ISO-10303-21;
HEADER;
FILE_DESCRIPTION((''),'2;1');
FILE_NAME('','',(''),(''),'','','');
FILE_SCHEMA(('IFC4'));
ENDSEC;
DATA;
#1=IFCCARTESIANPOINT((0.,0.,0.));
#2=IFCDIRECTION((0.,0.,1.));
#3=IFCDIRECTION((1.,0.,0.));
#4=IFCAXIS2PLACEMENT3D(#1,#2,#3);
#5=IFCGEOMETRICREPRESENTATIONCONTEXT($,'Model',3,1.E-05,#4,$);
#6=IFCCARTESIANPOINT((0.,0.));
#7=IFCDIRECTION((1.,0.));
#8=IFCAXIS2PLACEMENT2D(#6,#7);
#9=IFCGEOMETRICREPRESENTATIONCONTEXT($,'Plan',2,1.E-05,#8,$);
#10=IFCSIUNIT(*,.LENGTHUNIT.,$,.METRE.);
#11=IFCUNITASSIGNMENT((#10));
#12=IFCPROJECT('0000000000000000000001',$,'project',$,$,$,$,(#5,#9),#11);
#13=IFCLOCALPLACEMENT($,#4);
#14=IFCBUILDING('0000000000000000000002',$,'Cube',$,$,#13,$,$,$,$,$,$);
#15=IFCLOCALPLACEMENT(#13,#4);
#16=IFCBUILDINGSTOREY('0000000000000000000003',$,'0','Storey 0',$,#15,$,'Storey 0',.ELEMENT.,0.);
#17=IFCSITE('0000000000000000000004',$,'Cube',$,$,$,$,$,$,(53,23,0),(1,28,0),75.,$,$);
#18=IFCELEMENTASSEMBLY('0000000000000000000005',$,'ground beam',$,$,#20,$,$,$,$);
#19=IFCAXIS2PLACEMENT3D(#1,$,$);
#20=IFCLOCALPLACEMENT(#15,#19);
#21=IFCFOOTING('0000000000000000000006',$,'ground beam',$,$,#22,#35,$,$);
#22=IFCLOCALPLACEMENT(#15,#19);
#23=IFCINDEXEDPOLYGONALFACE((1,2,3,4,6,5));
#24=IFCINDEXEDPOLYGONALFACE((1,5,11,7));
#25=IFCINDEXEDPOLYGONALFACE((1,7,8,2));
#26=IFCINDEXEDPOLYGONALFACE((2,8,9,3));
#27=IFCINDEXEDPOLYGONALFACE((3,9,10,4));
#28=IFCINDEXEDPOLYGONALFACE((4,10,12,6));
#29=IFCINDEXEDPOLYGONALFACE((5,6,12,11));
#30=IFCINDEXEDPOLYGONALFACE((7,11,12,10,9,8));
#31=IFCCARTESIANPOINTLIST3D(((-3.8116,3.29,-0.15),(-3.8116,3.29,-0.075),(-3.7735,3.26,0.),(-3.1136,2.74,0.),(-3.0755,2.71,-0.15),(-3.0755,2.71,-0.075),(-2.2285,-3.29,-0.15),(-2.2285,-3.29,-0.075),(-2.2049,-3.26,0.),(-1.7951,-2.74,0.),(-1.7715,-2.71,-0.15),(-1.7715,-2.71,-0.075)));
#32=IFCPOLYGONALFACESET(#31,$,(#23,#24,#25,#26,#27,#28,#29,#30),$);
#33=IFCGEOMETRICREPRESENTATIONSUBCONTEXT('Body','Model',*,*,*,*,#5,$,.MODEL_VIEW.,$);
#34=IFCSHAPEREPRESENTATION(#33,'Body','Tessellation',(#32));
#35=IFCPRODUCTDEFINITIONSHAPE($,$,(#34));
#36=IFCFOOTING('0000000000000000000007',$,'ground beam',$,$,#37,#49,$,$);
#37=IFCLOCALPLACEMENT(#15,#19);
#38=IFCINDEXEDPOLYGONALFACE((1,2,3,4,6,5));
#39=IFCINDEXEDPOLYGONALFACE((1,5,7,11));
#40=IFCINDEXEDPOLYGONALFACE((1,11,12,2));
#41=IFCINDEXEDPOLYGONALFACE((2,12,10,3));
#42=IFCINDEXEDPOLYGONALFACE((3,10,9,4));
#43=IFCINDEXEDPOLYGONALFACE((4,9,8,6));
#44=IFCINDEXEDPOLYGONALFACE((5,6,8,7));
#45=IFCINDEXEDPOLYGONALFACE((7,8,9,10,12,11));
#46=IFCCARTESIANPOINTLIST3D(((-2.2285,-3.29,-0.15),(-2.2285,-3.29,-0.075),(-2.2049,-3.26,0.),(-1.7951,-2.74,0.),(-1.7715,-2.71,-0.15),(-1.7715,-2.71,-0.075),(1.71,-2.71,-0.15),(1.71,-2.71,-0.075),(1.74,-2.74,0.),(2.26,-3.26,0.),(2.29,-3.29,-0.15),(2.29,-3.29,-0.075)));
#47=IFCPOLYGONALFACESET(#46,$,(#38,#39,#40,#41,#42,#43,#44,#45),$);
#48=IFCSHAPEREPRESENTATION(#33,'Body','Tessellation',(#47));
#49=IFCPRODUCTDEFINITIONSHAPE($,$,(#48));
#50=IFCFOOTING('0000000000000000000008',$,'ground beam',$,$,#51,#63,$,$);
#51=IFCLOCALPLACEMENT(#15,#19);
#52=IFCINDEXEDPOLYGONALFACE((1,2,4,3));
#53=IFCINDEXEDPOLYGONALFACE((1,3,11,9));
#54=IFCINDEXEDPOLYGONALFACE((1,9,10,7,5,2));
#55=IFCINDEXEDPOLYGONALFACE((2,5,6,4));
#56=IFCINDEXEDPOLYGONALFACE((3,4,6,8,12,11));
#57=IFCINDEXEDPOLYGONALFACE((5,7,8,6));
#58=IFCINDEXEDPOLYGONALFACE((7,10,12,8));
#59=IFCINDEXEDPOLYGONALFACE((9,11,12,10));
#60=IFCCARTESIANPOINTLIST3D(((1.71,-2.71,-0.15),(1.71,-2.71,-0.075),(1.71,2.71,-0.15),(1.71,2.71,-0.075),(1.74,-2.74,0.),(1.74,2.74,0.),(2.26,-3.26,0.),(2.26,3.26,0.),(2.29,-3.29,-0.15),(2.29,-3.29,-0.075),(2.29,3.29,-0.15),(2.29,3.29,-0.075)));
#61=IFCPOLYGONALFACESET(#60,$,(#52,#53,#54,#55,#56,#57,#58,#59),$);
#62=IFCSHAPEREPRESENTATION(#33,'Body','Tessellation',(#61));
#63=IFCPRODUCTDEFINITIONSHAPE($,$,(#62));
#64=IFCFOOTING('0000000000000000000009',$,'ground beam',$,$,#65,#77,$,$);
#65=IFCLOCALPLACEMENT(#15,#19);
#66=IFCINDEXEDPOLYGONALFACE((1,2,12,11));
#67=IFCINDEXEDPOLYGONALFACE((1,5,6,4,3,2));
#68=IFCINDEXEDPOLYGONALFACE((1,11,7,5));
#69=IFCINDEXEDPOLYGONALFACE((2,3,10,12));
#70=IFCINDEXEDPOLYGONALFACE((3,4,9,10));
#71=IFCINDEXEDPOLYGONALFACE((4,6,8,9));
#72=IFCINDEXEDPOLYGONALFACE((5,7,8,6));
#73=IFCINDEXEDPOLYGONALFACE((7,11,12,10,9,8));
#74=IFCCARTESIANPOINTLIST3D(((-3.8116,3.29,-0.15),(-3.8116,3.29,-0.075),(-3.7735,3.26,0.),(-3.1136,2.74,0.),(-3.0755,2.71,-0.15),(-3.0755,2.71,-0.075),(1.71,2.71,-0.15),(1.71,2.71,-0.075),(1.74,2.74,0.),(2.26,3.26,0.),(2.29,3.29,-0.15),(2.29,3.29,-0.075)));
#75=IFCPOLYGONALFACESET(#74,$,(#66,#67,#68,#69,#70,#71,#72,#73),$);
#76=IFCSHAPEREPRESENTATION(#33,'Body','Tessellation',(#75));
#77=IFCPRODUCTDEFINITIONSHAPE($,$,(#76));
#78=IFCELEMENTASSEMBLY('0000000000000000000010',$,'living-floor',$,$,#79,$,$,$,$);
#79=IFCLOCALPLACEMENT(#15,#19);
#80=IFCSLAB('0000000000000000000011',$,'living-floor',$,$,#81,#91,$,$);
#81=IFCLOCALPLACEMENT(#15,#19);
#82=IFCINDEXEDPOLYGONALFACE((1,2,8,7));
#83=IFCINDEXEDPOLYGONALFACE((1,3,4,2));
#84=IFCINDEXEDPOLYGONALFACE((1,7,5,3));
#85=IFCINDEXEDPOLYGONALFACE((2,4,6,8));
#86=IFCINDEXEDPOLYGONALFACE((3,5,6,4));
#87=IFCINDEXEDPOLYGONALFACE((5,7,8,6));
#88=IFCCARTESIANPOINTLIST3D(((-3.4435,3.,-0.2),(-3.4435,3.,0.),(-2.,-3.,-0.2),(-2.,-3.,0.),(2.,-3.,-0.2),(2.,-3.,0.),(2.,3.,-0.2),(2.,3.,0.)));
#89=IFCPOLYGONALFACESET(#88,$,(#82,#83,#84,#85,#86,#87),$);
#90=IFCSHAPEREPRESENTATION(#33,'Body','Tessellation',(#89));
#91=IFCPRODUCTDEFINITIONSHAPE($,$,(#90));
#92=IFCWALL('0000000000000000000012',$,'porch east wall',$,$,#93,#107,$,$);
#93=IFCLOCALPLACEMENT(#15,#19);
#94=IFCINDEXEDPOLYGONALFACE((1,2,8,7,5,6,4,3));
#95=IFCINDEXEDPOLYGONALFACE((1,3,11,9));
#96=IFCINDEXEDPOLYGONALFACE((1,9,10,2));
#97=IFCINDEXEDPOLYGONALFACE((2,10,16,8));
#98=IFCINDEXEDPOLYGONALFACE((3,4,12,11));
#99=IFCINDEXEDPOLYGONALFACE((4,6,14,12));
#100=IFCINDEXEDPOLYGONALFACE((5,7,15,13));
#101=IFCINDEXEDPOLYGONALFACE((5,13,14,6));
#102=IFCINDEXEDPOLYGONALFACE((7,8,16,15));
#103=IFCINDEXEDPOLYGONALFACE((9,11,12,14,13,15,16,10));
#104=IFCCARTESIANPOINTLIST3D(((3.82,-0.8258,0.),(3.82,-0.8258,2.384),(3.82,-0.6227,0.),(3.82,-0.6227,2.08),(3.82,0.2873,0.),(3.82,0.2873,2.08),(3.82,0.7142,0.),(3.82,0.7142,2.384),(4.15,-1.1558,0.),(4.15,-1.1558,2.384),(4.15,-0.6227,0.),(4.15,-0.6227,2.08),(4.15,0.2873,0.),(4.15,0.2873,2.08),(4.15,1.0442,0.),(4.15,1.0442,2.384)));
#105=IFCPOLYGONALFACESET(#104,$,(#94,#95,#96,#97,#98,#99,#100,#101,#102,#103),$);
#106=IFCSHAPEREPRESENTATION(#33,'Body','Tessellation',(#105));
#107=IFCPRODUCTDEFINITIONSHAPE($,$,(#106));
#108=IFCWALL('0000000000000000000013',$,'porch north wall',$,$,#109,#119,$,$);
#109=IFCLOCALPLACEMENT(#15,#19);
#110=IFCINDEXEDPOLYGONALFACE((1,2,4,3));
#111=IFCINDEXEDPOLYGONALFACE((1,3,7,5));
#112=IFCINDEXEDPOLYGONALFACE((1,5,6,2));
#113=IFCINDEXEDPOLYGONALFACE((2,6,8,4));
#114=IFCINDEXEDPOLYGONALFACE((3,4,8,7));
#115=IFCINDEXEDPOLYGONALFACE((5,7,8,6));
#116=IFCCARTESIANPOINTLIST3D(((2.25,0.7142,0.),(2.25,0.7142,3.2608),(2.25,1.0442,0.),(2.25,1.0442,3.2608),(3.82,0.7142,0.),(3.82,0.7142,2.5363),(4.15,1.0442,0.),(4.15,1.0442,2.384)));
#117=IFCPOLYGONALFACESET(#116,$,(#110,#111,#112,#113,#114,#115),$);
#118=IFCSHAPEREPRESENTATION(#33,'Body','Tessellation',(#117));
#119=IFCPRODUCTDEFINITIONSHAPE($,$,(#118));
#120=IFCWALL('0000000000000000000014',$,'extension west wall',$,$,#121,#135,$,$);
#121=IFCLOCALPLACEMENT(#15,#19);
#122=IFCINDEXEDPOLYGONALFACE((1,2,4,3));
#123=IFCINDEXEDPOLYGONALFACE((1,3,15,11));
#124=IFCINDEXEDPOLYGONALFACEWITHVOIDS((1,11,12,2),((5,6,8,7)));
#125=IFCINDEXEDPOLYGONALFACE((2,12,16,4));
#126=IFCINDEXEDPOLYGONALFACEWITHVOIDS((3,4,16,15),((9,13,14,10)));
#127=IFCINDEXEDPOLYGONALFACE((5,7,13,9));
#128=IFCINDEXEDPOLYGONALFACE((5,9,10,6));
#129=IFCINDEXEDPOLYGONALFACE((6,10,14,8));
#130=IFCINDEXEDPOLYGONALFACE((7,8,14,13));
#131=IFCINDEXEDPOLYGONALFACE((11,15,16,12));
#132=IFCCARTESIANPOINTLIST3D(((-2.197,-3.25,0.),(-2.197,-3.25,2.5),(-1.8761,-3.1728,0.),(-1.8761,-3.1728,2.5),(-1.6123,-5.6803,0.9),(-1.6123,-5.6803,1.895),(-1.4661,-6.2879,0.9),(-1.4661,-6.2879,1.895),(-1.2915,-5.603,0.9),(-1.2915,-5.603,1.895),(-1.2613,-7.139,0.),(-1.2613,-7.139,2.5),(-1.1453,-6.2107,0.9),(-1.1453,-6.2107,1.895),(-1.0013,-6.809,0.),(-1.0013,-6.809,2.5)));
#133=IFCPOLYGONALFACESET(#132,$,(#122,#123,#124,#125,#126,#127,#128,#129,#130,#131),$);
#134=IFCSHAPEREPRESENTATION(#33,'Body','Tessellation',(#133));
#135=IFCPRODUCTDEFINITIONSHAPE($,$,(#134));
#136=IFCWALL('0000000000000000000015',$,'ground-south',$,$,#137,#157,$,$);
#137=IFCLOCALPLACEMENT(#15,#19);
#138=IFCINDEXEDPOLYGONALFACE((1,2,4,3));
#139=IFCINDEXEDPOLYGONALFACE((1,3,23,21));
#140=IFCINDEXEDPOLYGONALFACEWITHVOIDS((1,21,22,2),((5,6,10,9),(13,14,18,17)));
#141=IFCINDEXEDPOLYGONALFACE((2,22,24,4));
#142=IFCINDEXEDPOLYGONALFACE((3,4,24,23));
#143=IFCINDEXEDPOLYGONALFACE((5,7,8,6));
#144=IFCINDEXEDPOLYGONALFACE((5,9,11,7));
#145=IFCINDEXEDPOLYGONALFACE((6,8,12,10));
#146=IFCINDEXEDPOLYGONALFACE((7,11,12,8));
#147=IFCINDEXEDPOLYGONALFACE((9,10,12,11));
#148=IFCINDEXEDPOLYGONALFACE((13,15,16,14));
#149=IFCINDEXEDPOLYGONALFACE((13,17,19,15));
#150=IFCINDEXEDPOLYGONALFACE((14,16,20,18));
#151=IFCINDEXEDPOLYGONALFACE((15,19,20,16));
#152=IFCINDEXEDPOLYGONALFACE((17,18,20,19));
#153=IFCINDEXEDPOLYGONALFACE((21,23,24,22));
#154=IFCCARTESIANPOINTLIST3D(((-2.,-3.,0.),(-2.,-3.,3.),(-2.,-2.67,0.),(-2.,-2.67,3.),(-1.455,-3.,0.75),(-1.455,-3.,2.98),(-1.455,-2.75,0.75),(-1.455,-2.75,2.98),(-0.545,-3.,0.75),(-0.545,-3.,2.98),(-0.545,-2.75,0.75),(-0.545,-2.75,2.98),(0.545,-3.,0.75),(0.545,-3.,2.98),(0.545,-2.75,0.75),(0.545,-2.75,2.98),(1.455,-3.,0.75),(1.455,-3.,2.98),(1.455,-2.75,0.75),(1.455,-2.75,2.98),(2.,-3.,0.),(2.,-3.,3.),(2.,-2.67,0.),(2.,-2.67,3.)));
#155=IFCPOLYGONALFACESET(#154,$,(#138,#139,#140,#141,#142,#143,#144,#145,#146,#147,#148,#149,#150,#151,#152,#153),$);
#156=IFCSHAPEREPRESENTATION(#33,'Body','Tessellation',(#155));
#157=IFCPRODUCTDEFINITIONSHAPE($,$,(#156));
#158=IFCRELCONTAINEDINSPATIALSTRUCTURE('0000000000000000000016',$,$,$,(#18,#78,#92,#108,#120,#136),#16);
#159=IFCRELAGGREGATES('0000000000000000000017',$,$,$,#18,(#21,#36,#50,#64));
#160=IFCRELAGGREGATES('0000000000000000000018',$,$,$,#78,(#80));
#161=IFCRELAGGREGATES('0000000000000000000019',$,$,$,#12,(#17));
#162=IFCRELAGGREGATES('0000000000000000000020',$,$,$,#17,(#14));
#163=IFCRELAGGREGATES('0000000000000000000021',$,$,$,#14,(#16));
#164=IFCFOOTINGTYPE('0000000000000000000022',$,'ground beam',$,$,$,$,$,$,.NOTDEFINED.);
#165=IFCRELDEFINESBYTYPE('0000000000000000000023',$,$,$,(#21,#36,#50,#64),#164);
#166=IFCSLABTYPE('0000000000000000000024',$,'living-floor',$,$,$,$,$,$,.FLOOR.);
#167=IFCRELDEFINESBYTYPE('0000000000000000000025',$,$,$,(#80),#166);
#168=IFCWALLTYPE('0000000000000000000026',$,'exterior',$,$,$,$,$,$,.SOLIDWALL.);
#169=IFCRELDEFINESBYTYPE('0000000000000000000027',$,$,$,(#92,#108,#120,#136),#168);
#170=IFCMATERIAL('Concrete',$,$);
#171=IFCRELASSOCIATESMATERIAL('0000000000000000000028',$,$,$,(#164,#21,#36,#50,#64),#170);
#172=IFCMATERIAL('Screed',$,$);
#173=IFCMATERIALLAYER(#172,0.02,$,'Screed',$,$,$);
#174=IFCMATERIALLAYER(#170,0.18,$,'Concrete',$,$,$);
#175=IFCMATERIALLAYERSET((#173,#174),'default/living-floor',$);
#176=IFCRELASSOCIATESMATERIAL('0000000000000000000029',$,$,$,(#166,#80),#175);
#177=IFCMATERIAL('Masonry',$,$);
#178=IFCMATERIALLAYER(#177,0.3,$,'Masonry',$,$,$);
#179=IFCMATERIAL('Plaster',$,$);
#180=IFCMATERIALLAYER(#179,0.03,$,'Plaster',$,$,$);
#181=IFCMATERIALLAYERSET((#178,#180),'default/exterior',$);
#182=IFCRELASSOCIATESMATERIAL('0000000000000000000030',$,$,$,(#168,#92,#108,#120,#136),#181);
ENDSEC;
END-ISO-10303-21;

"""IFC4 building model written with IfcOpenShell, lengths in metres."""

from ifc_helpers import new_model, si_unit, frame, origin, origin_with_axes, origin_2d_with_axis, place, context, subcontext, project, spatial, polyline, line, indexed_curve, outline, extrude, clip, halfspace, source, transform, mapped, material, layer, layer_set, layer_usage, material_profile, profile_set, profile_usage, type_object, element, aggregate, save


model = new_model("IFC4")

# Units and contexts
model_context = context("Model", 3, precision=1e-05, world=origin_with_axes())
plan_context = context("Plan", 2, precision=1e-05, world=origin_2d_with_axis())
body_context = subcontext(model_context, "Body", "Model", "MODEL_VIEW")
ifc_project = project(units=[si_unit("LENGTHUNIT", "METRE")], contexts=[model_context, plan_context])

# Site, building, storey
site = spatial("IfcSite", under=ifc_project, Name="Cube", RefLatitude=(53, 23, 0), RefLongitude=(1, 28, 0), RefElevation=75.0)
building_placement = place(None, origin_with_axes())
building = spatial("IfcBuilding", under=site, at=building_placement, Name="Cube")
storey_placement = place(building_placement, origin_with_axes())
storey = spatial("IfcBuildingStorey", under=building, at=storey_placement, Name="0", Description="Storey 0", LongName="Storey 0", CompositionType="ELEMENT", Elevation=0.0)

# Element assembly, footings
assembly_1_placement = place(storey_placement, origin_with_axes())
assembly_1 = element("IfcElementAssembly", 1, at=assembly_1_placement, inside=storey, Name="ground beam")
ifc_material_1 = material(Name="Concrete")
ifc_material_profile = material_profile(ifc_material_1, outline(polyline([(-0.26, 0.0), (-0.29, -0.075), (-0.29, -0.15), (0.29, -0.15), (0.29, -0.075), (0.26, 0.0), (-0.26, 0.0)])))
ifc_profile_set = profile_set([ifc_material_profile])
ifc_profile_usage_1 = profile_usage(ifc_profile_set)
footing_type = type_object("IfcFootingType", Name="ground beam", PredefinedType="NOTDEFINED", material=ifc_profile_set)
footing_1_placement = place(assembly_1_placement, frame((-1.7661, -3.9723, 0.0), z_axis=(-0.233915, 0.972257, 0.0), x_axis=(-0.972257, -0.233915, 0.0)))
footing_1 = element("IfcFooting", 2, at=footing_1_placement, type_object=footing_type, material=ifc_profile_usage_1, Name="ground beam", context=body_context, shape_type="Clipping", body=[
    clip(clip(extrude(outline(polyline([(-0.26, 0.0), (-0.29, -0.075), (-0.29, -0.15), (0.29, -0.15), (0.29, -0.075), (0.26, 0.0), (-0.26, 0.0)])), origin_with_axes(), (0.0, 0.0, 1.0), 8.1712), halfspace(frame((0.0, 0.0, 1.0), z_axis=(-0.618904, 0.0, -0.785467), x_axis=(0.0, 1.0, 0.0)), False)), halfspace(frame((0.0, 0.0, 7.1712), z_axis=(-0.785467, 0.0, 0.618904), x_axis=(0.0, 1.0, 0.0)), False)),
])
ifc_profile_usage_2 = profile_usage(ifc_profile_set)
footing_2_placement = place(assembly_1_placement, frame((3.0, -3.0, 0.0), z_axis=(-1.0, 0.0, 0.0), x_axis=(0.0, -1.0, 0.0)))
footing_2 = element("IfcFooting", 3, at=footing_2_placement, type_object=footing_type, material=ifc_profile_usage_2, Name="ground beam", context=body_context, shape_type="Clipping", body=[
    clip(clip(extrude(outline(polyline([(-0.26, 0.0), (-0.29, -0.075), (-0.29, -0.15), (0.29, -0.15), (0.29, -0.075), (0.26, 0.0), (-0.26, 0.0)])), origin_with_axes(), (0.0, 0.0, 1.0), 6.0), halfspace(frame((0.0, 0.0, 1.0), z_axis=(-0.707107, 0.0, -0.707107), x_axis=(0.0, 1.0, 0.0)), False)), halfspace(frame((0.0, 0.0, 5.0), z_axis=(-0.618904, 0.0, 0.785467), x_axis=(0.0, 1.0, 0.0)), False)),
])
ifc_profile_usage_3 = profile_usage(ifc_profile_set)
footing_3_placement = place(assembly_1_placement, frame((2.0, 4.0, 0.0), z_axis=(0.0, -1.0, 0.0), x_axis=(1.0, 0.0, 0.0)))
footing_3 = element("IfcFooting", 4, at=footing_3_placement, type_object=footing_type, material=ifc_profile_usage_3, Name="ground beam", context=body_context, shape_type="Clipping", body=[
    clip(clip(extrude(outline(polyline([(-0.26, 0.0), (-0.29, -0.075), (-0.29, -0.15), (0.29, -0.15), (0.29, -0.075), (0.26, 0.0), (-0.26, 0.0)])), origin_with_axes(), (0.0, 0.0, 1.0), 8.0), halfspace(frame((0.0, 0.0, 1.0), z_axis=(-0.707107, 0.0, -0.707107), x_axis=(0.0, 1.0, 0.0)), False)), halfspace(frame((0.0, 0.0, 7.0), z_axis=(-0.707107, 0.0, 0.707107), x_axis=(0.0, 1.0, 0.0)), False)),
])
ifc_profile_usage_4 = profile_usage(ifc_profile_set)
footing_4_placement = place(assembly_1_placement, frame((-4.4435, 3.0, 0.0), z_axis=(1.0, 0.0, 0.0), x_axis=(0.0, 1.0, 0.0)))
footing_4 = element("IfcFooting", 5, at=footing_4_placement, type_object=footing_type, material=ifc_profile_usage_4, Name="ground beam", context=body_context, shape_type="Clipping", body=[
    clip(clip(extrude(outline(polyline([(-0.26, 0.0), (-0.29, -0.075), (-0.29, -0.15), (0.29, -0.15), (0.29, -0.075), (0.26, 0.0), (-0.26, 0.0)])), origin_with_axes(), (0.0, 0.0, 1.0), 7.4435), halfspace(frame((0.0, 0.0, 1.0), z_axis=(-0.785467, 0.0, -0.618904), x_axis=(0.0, 1.0, 0.0)), False)), halfspace(frame((0.0, 0.0, 6.4435), z_axis=(-0.707107, 0.0, 0.707107), x_axis=(0.0, 1.0, 0.0)), False)),
])
aggregate(assembly_1, [footing_1, footing_2, footing_3, footing_4])

# Element assembly, slab
assembly_2_placement = place(storey_placement, origin_with_axes())
assembly_2 = element("IfcElementAssembly", 6, at=assembly_2_placement, inside=storey, Name="living-floor")
ifc_material_2 = material(Name="Screed")
ifc_layer_1 = layer(ifc_material_2, 0.02, Name="Screed")
ifc_layer_2 = layer(ifc_material_1, 0.18, Name="Concrete")
ifc_layer_set_1 = layer_set([ifc_layer_1, ifc_layer_2], Name="default/living-floor")
ifc_layer_usage_1 = layer_usage(ifc_layer_set_1, "AXIS3", "POSITIVE", 0.0)
slab_type = type_object("IfcSlabType", Name="living-floor", PredefinedType="FLOOR", material=ifc_layer_set_1)
slab_placement = place(assembly_2_placement, frame((2.0, 3.0, -0.2), z_axis=(0.0, 0.0, -1.0), x_axis=(0.0, 1.0, 0.0)))
slab = element("IfcSlab", 7, at=slab_placement, type_object=slab_type, material=ifc_layer_usage_1, Name="living-floor", context=body_context, shape_type="SweptSolid", body=[
    extrude(outline(polyline([(0.0, 0.0), (-6.0, 0.0), (-6.0, -4.0), (0.0, -5.4435), (0.0, 0.0)])), origin(), (0.0, 0.0, -1.0), 0.2),
])
aggregate(assembly_2, [slab])

# Wall, opening
ifc_material_3 = material(Name="Masonry")
ifc_layer_3 = layer(ifc_material_3, 0.3, Name="Masonry")
ifc_material_4 = material(Name="Plaster")
ifc_layer_4 = layer(ifc_material_4, 0.03, Name="Plaster")
ifc_layer_set_2 = layer_set([ifc_layer_3, ifc_layer_4], Name="default/exterior")
wall_type = type_object("IfcWallType", Name="exterior", PredefinedType="SOLIDWALL", material=ifc_layer_set_2)
ifc_layer_usage_2 = layer_usage(ifc_layer_set_2, "AXIS2", "POSITIVE", 0.0)
wall_1_placement = place(storey_placement, frame((4.15, -1.1558, 0.0), z_axis=(0.0, 0.0, 1.0), x_axis=(0.0, 1.0, 0.0)))
wall_1 = element("IfcWall", 8, at=wall_1_placement, inside=storey, type_object=wall_type, material=ifc_layer_usage_2, Name="porch east wall", context=body_context, shape_type="SweptSolid", body=[
    extrude(outline(indexed_curve([(0.0, 0.0), (0.33, 0.33), (1.87, 0.33), (2.2, 0.0)], segments=[line(1, 2, 3, 4, 1)])), origin_with_axes(), (0.0, 0.0, 1.0), 2.384),
])
shared_shape = source(origin_with_axes(), body_context, "Body", "SweptSolid", [
    extrude(outline(indexed_curve([(0.0, 0.0), (0.91, 0.0), (0.91, 2.08), (0.0, 2.08)], segments=[line(1, 2, 3, 4, 1)])), frame((0.0, -0.6, 0.0), z_axis=(0.0, -1.0, 0.0), x_axis=(1.0, 0.0, 0.0)), (0.0, 0.0, -1.0), 1.2),
])
opening_1_placement = place(wall_1_placement, frame((0.5331, 0.0, 0.0), z_axis=(0.0, 0.0, 1.0), x_axis=(1.0, 0.0, 0.0)))
element("IfcOpeningElement", 9, at=opening_1_placement, cuts=wall_1, PredefinedType="OPENING", context=body_context, shape_type="MappedRepresentation", body=[
    mapped(shared_shape, transform((0.0, 0.0, 0.0), x_axis=(1.0, 0.0, 0.0), y_axis=(0.0, 1.0, 0.0), z_axis=(0.0, 0.0, 1.0), scale=1.0)),
])

# Wall
ifc_layer_usage_3 = layer_usage(ifc_layer_set_2, "AXIS2", "POSITIVE", 0.0)
wall_2_placement = place(storey_placement, frame((4.15, 1.0442, 0.0), z_axis=(0.0, 0.0, 1.0), x_axis=(-1.0, 0.0, 0.0)))
element("IfcWall", 10, at=wall_2_placement, inside=storey, type_object=wall_type, material=ifc_layer_usage_3, Name="porch north wall", context=body_context, shape_type="Clipping", body=[
    clip(extrude(outline(indexed_curve([(0.0, 0.0), (1.9, 0.0), (1.9, 0.33), (0.33, 0.33)], segments=[line(1, 2, 3, 4, 1)])), origin_with_axes(), (0.0, 0.0, 1.0), 3.5), halfspace(frame((0.0, 0.0, 2.384), z_axis=(-0.419, 0.0, 0.908), x_axis=(0.0, 1.0, 0.0)), False)),
])

# Wall, opening
ifc_layer_usage_4 = layer_usage(ifc_layer_set_2, "AXIS2", "POSITIVE", 0.0)
wall_3_placement = place(storey_placement, frame((-2.197, -3.25, 0.0), z_axis=(0.0, 0.0, 1.0), x_axis=(0.233916, -0.972257, 0.0)))
wall_3 = element("IfcWall", 11, at=wall_3_placement, inside=storey, type_object=wall_type, material=ifc_layer_usage_4, Name="extension west wall", context=body_context, shape_type="SweptSolid", body=[
    extrude(outline(indexed_curve([(0.0, 0.0), (0.0, 0.33), (3.7399, 0.33), (4.0, 0.0)], segments=[line(1, 2, 3, 4, 1)])), origin_with_axes(), (0.0, 0.0, 1.0), 2.5),
])
opening_2_placement = place(wall_3_placement, frame((2.4996, -0.0501, 0.9), z_axis=(0.0, 0.0, 1.0), x_axis=(1.0, 0.000142, 0.0)))
element("IfcOpeningElement", 12, at=opening_2_placement, cuts=wall_3, PredefinedType="OPENING", context=body_context, shape_type="SweptSolid", body=[
    extrude(outline(indexed_curve([(0.0, 0.0), (0.0, 0.43), (0.625, 0.43), (0.625, 0.0), (0.0, 0.0)], self_intersect=False)), origin_with_axes(), (0.0, 0.0, 1.0), 0.995),
])

# Wall, openings
ifc_layer_usage_5 = layer_usage(ifc_layer_set_2, "AXIS2", "POSITIVE", 0.0)
wall_4_placement = place(storey_placement, frame((-2.0, -3.0, 0.0), z_axis=(0.0, 0.0, 1.0), x_axis=(1.0, 0.0, 0.0)))
wall_4 = element("IfcWall", 13, at=wall_4_placement, inside=storey, type_object=wall_type, material=ifc_layer_usage_5, Name="ground-south", context=body_context, shape_type="SweptSolid", body=[
    extrude(outline(indexed_curve([(0.0, 0.0), (0.0, 0.33), (4.0, 0.33), (4.0, 0.0), (0.0, 0.0)], self_intersect=False)), origin_with_axes(), (0.0, 0.0, 1.0), 3.0),
])
opening_3_placement = place(wall_4_placement, frame((0.545, -0.25, 0.75), z_axis=(0.0, 0.0, 1.0), x_axis=(1.0, 0.0, 0.0)))
element("IfcOpeningElement", 14, at=opening_3_placement, cuts=wall_4, PredefinedType="OPENING", context=body_context, shape_type="SweptSolid", body=[
    extrude(outline(indexed_curve([(0.0, 0.0), (0.0, 0.5), (0.91, 0.5), (0.91, 0.0), (0.0, 0.0)], self_intersect=False)), origin_with_axes(), (0.0, 0.0, 1.0), 2.23),
])
opening_4_placement = place(wall_4_placement, frame((2.545, -0.25, 0.75), z_axis=(0.0, 0.0, 1.0), x_axis=(1.0, 0.0, 0.0)))
element("IfcOpeningElement", 15, at=opening_4_placement, cuts=wall_4, PredefinedType="OPENING", context=body_context, shape_type="SweptSolid", body=[
    extrude(outline(indexed_curve([(0.0, 0.0), (0.0, 0.5), (0.91, 0.5), (0.91, 0.0), (0.0, 0.0)], self_intersect=False)), origin_with_axes(), (0.0, 0.0, 1.0), 2.23),
])

save(model, "model.ifc")
